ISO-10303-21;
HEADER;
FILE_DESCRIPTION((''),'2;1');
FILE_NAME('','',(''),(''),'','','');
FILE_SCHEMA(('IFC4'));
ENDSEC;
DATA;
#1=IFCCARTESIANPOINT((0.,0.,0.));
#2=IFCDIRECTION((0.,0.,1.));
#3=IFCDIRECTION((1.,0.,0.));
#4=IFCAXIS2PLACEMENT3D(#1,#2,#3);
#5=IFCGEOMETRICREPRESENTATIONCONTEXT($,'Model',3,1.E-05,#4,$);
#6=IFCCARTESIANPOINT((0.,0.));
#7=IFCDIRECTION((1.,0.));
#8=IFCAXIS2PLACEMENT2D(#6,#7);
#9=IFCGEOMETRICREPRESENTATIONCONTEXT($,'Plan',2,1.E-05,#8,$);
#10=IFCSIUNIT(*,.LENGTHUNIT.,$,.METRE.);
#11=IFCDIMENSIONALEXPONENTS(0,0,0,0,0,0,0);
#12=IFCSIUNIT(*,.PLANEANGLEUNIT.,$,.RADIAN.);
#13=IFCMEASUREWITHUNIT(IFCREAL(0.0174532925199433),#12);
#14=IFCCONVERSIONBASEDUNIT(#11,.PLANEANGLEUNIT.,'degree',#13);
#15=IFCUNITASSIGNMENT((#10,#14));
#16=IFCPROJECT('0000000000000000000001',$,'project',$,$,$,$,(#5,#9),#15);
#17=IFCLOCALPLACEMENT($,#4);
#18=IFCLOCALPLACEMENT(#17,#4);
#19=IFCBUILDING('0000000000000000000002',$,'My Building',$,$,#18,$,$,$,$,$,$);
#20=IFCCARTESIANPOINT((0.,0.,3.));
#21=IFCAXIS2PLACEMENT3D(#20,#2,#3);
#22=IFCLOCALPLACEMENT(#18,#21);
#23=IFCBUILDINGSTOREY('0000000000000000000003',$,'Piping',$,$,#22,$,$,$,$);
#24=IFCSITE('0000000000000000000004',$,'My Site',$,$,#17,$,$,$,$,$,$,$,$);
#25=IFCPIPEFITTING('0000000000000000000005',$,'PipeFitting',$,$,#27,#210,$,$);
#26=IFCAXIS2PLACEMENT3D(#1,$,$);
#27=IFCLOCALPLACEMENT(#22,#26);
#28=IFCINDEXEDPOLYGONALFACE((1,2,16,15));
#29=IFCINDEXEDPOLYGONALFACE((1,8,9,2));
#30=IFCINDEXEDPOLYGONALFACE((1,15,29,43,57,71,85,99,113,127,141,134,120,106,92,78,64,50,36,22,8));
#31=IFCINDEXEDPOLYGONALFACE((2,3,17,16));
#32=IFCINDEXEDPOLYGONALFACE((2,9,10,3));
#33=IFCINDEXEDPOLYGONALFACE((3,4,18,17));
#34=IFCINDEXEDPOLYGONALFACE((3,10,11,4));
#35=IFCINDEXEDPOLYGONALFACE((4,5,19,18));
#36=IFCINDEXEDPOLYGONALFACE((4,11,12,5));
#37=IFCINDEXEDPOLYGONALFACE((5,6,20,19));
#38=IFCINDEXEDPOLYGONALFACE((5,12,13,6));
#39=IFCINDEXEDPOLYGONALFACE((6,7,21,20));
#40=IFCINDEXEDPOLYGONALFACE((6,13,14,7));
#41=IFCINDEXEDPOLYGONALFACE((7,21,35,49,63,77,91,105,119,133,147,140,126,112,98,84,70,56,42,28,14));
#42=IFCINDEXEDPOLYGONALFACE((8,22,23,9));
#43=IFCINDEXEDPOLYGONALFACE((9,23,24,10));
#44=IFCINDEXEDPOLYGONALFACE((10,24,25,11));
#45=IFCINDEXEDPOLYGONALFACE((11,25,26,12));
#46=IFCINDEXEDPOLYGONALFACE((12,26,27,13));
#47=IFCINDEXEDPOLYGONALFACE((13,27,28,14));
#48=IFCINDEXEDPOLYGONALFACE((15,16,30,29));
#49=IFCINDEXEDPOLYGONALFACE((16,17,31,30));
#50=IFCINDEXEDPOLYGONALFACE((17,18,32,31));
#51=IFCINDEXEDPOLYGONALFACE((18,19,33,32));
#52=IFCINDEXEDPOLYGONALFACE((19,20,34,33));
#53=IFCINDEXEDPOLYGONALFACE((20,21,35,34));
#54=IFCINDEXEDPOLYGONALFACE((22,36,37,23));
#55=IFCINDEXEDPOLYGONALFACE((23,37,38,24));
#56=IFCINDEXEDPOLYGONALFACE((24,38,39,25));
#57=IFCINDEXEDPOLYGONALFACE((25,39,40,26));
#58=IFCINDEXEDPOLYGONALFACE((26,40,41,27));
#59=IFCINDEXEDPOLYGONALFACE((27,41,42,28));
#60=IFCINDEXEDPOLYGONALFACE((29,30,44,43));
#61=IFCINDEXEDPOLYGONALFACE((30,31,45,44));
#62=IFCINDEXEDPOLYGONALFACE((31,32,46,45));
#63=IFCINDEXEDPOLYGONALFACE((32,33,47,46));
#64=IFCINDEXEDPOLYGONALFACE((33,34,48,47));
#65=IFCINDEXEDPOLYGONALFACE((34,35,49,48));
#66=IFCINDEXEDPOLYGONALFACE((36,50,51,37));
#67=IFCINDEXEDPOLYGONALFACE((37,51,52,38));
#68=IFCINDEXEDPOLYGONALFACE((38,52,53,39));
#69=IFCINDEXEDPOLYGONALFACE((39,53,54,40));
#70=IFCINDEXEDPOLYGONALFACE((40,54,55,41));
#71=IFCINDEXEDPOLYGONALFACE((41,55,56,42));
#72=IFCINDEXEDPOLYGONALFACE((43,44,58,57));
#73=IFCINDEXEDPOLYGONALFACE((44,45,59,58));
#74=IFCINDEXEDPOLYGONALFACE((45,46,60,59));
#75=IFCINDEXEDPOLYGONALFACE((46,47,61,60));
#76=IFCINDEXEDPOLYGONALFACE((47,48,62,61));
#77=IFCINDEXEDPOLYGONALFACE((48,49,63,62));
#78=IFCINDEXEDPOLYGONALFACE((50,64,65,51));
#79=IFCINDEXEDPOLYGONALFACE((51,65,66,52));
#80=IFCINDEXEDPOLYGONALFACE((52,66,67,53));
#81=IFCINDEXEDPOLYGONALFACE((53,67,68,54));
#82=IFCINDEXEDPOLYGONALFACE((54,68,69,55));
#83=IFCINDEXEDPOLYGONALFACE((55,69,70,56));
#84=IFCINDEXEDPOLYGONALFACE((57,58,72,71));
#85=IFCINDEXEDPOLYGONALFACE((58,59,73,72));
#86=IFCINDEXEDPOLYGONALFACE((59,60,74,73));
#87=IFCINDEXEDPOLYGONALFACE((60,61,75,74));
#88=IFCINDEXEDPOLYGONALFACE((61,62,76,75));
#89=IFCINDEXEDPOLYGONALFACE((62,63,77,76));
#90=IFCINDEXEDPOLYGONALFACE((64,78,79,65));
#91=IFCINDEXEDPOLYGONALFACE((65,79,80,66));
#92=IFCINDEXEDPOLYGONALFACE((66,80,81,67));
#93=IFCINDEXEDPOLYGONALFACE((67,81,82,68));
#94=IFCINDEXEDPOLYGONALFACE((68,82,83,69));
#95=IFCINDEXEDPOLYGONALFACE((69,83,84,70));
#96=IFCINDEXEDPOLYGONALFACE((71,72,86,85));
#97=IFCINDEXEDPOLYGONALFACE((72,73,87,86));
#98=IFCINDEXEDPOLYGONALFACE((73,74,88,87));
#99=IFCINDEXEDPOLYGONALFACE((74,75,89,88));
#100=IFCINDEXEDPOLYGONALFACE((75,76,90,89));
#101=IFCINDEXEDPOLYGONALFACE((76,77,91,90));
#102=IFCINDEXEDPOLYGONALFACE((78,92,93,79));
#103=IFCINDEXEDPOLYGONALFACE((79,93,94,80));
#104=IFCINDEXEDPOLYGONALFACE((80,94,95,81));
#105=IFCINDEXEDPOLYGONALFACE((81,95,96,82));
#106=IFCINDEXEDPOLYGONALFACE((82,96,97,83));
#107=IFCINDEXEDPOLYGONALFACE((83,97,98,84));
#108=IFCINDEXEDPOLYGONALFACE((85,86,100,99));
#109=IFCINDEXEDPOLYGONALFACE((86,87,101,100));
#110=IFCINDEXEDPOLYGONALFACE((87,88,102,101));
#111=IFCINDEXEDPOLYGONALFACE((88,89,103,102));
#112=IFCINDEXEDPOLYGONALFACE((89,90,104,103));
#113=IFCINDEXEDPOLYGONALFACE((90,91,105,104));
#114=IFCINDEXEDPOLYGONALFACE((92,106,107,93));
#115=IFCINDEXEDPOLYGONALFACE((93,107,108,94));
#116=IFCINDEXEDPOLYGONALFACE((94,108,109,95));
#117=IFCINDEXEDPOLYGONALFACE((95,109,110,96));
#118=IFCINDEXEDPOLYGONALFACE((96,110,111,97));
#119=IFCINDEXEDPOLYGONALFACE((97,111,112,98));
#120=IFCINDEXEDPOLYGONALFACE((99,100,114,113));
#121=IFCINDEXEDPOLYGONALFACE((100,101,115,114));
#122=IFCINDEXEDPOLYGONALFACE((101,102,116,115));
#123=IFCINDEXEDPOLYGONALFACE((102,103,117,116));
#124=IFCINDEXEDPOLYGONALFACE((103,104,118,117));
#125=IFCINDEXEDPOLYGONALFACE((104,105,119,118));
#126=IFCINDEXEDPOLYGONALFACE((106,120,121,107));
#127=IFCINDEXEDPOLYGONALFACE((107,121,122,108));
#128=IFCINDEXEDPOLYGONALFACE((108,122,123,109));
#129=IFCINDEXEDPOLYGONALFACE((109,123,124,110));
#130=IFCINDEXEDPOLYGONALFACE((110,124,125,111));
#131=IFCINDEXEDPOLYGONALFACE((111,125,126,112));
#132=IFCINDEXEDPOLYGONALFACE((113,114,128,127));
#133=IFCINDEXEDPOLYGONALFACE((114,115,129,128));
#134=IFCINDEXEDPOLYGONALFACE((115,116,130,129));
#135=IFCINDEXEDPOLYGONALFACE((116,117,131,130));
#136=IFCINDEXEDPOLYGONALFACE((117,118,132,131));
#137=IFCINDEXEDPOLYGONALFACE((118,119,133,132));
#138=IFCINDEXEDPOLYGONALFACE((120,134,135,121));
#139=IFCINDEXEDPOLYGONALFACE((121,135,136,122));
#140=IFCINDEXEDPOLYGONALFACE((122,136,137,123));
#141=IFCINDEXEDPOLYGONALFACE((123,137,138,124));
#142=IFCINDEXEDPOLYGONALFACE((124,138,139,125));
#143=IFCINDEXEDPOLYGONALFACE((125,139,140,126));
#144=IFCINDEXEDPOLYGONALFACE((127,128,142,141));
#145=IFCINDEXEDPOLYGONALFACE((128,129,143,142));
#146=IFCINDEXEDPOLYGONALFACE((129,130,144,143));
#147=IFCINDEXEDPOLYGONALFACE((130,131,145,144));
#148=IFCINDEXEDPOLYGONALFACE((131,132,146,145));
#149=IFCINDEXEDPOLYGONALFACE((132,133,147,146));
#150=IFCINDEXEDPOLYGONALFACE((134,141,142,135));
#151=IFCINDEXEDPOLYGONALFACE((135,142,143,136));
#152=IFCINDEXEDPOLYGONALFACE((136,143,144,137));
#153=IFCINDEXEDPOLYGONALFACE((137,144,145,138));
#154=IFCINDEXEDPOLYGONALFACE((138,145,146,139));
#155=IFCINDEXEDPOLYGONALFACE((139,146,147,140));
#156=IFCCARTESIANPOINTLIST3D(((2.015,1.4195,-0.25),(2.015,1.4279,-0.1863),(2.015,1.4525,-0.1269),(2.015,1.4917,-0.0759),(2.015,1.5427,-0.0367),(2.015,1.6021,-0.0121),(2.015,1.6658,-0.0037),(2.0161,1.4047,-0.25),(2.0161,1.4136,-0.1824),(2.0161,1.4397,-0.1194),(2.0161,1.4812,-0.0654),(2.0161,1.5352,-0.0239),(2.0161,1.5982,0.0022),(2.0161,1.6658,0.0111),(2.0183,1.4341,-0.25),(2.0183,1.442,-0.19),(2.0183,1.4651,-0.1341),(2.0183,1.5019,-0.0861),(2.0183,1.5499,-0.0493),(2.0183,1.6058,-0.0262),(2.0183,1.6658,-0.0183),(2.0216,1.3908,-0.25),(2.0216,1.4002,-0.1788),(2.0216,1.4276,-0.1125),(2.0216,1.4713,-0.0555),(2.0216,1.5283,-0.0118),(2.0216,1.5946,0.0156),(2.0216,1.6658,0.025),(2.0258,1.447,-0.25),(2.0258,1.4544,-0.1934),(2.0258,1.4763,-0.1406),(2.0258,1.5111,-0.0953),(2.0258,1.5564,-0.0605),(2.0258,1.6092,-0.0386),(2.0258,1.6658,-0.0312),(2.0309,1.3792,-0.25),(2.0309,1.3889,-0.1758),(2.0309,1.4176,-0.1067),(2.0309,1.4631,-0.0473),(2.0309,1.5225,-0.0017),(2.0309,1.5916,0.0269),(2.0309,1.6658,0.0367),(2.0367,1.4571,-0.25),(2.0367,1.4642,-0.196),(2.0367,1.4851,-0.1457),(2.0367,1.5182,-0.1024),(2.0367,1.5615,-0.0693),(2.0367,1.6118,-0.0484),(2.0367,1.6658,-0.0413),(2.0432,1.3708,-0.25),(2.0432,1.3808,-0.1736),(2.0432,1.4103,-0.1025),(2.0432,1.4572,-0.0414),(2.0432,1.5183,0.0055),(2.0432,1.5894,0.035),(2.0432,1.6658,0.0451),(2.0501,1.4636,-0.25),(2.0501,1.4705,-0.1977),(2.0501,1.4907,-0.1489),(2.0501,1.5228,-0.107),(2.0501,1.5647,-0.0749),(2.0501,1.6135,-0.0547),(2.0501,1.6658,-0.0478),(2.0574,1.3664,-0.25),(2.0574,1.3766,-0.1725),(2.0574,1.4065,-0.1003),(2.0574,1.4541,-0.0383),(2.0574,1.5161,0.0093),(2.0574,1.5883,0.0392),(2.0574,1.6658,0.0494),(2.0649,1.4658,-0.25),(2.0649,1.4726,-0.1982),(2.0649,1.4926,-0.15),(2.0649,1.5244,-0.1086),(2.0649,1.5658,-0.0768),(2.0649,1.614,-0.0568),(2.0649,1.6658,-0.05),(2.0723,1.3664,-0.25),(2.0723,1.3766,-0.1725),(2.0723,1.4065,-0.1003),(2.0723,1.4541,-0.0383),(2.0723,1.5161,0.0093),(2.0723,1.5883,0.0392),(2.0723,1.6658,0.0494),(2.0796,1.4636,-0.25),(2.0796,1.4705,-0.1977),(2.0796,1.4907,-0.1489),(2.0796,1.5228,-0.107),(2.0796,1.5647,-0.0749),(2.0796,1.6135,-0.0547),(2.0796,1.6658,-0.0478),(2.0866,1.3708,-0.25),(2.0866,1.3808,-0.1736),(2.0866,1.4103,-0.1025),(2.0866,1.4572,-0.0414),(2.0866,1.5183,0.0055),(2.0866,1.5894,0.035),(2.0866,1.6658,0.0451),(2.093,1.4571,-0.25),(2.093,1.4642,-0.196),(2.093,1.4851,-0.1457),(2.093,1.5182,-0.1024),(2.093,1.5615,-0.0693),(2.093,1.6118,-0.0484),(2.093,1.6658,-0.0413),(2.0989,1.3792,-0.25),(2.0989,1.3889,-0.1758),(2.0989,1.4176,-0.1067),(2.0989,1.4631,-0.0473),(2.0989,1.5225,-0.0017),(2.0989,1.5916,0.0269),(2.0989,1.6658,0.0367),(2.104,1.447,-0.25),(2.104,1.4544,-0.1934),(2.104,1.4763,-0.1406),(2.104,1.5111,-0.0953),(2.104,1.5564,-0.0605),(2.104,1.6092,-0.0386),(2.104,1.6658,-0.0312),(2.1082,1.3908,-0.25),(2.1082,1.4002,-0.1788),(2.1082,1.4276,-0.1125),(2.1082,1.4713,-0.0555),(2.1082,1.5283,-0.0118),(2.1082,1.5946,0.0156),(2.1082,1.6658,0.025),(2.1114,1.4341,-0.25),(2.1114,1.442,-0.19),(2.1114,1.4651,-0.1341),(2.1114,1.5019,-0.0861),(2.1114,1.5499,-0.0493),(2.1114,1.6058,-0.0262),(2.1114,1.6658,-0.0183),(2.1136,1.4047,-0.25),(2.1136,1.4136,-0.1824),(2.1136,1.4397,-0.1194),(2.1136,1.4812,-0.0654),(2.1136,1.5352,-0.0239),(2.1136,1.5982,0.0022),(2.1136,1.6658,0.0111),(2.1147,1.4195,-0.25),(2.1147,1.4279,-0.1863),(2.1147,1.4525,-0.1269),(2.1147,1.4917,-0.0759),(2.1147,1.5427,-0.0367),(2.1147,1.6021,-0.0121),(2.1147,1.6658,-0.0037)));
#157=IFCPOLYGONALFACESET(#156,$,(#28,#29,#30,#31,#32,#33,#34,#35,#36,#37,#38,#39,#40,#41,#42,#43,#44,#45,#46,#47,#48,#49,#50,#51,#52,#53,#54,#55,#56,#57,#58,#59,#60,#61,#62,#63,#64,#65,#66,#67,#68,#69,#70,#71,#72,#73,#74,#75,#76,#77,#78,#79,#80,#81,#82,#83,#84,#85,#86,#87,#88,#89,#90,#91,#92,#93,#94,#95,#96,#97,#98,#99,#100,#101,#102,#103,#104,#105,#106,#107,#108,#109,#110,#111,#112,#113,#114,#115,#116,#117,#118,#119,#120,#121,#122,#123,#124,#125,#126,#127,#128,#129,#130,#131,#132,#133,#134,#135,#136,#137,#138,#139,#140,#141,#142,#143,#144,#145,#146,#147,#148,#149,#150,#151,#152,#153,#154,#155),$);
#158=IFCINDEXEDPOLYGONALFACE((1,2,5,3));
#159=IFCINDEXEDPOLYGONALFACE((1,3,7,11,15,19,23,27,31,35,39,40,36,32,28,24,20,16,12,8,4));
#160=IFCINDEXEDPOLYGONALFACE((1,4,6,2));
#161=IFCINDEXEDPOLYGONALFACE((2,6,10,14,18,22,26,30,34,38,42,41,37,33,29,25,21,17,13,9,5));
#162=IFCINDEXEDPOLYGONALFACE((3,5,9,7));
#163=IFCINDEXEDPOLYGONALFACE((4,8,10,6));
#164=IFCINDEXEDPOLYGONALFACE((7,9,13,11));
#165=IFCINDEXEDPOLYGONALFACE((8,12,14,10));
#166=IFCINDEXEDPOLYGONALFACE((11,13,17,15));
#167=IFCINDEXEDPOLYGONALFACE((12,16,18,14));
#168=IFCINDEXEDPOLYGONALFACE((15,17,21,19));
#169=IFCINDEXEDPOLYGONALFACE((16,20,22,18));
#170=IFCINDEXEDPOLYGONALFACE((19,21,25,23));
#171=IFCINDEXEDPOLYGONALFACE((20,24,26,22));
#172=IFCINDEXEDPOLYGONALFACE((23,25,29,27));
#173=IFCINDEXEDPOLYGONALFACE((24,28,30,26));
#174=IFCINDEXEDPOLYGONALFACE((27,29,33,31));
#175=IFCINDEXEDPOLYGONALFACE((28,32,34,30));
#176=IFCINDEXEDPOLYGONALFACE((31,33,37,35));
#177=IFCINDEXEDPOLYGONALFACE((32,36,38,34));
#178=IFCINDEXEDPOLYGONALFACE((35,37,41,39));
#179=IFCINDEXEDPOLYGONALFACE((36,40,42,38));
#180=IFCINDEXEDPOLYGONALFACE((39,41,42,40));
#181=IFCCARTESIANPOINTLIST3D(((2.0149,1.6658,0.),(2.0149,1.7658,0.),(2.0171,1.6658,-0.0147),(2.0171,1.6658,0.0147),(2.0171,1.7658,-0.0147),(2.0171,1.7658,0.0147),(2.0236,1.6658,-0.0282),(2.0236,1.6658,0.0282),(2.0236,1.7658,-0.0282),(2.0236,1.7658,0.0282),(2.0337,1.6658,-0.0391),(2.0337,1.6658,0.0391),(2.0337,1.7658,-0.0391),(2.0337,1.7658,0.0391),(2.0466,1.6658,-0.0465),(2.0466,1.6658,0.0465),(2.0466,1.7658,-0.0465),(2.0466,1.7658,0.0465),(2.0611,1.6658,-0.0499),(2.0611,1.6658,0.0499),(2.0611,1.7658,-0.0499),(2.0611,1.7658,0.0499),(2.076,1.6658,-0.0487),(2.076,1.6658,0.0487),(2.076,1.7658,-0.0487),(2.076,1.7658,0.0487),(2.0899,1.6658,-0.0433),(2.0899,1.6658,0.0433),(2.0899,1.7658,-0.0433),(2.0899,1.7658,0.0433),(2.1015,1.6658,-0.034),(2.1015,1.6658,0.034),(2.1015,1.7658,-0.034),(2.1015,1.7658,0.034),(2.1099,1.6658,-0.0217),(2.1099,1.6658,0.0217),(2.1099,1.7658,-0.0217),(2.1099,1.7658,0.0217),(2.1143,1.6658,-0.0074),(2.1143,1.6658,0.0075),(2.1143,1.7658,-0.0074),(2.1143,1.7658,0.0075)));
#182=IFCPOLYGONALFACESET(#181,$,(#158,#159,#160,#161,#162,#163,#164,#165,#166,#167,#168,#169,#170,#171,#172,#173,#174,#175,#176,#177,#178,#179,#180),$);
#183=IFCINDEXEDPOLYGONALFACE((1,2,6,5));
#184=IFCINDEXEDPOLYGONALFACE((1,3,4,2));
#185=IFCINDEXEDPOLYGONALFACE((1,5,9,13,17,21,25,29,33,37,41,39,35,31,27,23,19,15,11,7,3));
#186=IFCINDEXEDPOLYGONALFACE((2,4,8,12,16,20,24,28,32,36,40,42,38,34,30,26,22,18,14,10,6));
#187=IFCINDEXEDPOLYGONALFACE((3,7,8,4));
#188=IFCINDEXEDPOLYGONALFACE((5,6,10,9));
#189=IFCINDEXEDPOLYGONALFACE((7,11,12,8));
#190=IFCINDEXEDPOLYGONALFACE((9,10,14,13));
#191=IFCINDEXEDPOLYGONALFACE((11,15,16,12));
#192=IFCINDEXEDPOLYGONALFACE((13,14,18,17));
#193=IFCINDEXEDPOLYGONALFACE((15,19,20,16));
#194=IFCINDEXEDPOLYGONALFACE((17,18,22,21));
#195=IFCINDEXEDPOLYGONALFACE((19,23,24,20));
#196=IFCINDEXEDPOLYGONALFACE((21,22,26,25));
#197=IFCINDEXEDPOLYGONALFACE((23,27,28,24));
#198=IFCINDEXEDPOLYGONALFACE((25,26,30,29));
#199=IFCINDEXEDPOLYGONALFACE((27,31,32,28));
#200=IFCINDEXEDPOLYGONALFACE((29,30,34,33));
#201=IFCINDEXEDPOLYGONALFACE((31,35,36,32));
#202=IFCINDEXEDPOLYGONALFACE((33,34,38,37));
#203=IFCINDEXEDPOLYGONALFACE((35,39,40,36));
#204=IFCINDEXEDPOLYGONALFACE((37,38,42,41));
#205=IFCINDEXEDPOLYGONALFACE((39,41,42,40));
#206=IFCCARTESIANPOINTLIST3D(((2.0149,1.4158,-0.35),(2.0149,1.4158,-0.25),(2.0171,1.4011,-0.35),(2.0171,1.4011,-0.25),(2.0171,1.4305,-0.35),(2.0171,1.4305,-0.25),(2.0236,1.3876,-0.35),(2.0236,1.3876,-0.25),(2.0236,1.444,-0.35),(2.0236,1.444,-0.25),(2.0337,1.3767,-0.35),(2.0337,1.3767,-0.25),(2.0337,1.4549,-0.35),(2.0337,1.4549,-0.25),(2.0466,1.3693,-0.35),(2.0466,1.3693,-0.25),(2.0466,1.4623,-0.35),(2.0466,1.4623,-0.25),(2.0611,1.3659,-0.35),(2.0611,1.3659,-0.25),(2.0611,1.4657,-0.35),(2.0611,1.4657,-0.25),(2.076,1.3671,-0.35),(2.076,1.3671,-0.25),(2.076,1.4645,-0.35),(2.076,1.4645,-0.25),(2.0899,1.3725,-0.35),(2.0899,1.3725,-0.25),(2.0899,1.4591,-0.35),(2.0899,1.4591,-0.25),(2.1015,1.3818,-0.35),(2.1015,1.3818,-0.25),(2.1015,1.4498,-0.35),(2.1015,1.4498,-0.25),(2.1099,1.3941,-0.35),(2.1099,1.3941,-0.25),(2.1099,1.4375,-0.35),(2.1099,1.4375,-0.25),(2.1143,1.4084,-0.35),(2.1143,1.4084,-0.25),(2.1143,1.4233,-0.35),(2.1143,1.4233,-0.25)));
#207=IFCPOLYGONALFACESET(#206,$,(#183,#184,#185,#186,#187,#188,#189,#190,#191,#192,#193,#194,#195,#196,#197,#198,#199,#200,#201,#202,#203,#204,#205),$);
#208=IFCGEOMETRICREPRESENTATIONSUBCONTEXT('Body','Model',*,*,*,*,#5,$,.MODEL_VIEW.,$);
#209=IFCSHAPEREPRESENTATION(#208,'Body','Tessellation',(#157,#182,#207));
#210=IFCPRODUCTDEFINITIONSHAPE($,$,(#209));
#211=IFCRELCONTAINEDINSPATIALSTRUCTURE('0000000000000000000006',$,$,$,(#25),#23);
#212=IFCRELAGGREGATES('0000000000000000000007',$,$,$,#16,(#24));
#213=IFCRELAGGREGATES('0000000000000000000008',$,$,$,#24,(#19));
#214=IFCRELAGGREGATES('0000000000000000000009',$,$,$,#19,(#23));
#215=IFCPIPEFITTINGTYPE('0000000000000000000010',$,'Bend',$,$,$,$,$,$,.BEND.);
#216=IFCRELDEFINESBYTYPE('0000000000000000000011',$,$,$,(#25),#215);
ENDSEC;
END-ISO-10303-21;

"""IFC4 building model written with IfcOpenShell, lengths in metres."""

from ifc_helpers import new_model, entity, si_unit, converted_unit, frame, origin_with_axes, origin_2d_with_axis, place, context, subcontext, project, spatial, circle, extrude, source, transform, mapped, type_object, type_shapes, element, save


model = new_model("IFC4")

# Units and contexts
model_context = context("Model", 3, precision=1e-05, world=origin_with_axes())
plan_context = context("Plan", 2, precision=1e-05, world=origin_2d_with_axis())
body_context = subcontext(model_context, "Body", "Model", "MODEL_VIEW")
ifc_project = project(units=[si_unit("LENGTHUNIT", "METRE"), converted_unit("PLANEANGLEUNIT", "degree", entity("IfcReal", 0.0174532925199433), si_unit("PLANEANGLEUNIT", "RADIAN"), dimensions=[0, 0, 0, 0, 0, 0, 0])], contexts=[model_context, plan_context])

# Site, building, storey
site_placement = place(None, origin_with_axes())
site = spatial("IfcSite", under=ifc_project, at=site_placement, Name="My Site")
building_placement = place(site_placement, origin_with_axes())
building = spatial("IfcBuilding", under=site, at=building_placement, Name="My Building")
storey_placement = place(building_placement, frame((0.0, 0.0, 3.0), z_axis=(0.0, 0.0, 1.0), x_axis=(1.0, 0.0, 0.0)))
storey = spatial("IfcBuildingStorey", under=building, at=storey_placement, Name="Piping")

# Pipe fitting
pipe_fitting_type_1 = type_object("IfcPipeFittingType", Name="Bend", PredefinedType="BEND")
shared_shape = source(origin_with_axes(), body_context, "Body", "SolidModel", [
    entity("IfcSweptDiskSolid", entity("IfcIndexedPolyCurve", entity("IfcCartesianPointList3D", [[0.0, 0.0, -0.1], [0.0, -0.0732, -0.2768], [0.0, -0.25, -0.35]]), [entity("IfcArcIndex", [1, 2, 3])]), 0.05),
    extrude(circle(Radius=0.05), origin_with_axes(), (0.0, 0.0, -1.0), 0.1),
    extrude(circle(Radius=0.05), frame((0.0, -0.25, -0.35), z_axis=(0.0, -1.0, 0.0), x_axis=(1.0, 0.0, 0.0)), (0.0, 0.0, 1.0), 0.1),
])
type_shapes(pipe_fitting_type_1, [shared_shape])
for number, where, z_axis, x_axis, name in (
    (1, (2.0649, 1.7658, 0.0), (0.0, 1.0, 0.0), (-1.0, 0.0, 0.0), "PipeFitting"),
):
    element("IfcPipeFitting", number, at=place(storey_placement, frame(where, z_axis=z_axis, x_axis=x_axis)), inside=storey, type_object=pipe_fitting_type_1, Name=name, context=body_context, shape_type="MappedRepresentation", body=[
        mapped(shared_shape, transform((0.0, 0.0, 0.0), x_axis=(1.0, 0.0, 0.0), y_axis=(0.0, 1.0, 0.0), z_axis=(0.0, 0.0, 1.0), scale=1.0)),
    ])

save(model, "model.ifc")
